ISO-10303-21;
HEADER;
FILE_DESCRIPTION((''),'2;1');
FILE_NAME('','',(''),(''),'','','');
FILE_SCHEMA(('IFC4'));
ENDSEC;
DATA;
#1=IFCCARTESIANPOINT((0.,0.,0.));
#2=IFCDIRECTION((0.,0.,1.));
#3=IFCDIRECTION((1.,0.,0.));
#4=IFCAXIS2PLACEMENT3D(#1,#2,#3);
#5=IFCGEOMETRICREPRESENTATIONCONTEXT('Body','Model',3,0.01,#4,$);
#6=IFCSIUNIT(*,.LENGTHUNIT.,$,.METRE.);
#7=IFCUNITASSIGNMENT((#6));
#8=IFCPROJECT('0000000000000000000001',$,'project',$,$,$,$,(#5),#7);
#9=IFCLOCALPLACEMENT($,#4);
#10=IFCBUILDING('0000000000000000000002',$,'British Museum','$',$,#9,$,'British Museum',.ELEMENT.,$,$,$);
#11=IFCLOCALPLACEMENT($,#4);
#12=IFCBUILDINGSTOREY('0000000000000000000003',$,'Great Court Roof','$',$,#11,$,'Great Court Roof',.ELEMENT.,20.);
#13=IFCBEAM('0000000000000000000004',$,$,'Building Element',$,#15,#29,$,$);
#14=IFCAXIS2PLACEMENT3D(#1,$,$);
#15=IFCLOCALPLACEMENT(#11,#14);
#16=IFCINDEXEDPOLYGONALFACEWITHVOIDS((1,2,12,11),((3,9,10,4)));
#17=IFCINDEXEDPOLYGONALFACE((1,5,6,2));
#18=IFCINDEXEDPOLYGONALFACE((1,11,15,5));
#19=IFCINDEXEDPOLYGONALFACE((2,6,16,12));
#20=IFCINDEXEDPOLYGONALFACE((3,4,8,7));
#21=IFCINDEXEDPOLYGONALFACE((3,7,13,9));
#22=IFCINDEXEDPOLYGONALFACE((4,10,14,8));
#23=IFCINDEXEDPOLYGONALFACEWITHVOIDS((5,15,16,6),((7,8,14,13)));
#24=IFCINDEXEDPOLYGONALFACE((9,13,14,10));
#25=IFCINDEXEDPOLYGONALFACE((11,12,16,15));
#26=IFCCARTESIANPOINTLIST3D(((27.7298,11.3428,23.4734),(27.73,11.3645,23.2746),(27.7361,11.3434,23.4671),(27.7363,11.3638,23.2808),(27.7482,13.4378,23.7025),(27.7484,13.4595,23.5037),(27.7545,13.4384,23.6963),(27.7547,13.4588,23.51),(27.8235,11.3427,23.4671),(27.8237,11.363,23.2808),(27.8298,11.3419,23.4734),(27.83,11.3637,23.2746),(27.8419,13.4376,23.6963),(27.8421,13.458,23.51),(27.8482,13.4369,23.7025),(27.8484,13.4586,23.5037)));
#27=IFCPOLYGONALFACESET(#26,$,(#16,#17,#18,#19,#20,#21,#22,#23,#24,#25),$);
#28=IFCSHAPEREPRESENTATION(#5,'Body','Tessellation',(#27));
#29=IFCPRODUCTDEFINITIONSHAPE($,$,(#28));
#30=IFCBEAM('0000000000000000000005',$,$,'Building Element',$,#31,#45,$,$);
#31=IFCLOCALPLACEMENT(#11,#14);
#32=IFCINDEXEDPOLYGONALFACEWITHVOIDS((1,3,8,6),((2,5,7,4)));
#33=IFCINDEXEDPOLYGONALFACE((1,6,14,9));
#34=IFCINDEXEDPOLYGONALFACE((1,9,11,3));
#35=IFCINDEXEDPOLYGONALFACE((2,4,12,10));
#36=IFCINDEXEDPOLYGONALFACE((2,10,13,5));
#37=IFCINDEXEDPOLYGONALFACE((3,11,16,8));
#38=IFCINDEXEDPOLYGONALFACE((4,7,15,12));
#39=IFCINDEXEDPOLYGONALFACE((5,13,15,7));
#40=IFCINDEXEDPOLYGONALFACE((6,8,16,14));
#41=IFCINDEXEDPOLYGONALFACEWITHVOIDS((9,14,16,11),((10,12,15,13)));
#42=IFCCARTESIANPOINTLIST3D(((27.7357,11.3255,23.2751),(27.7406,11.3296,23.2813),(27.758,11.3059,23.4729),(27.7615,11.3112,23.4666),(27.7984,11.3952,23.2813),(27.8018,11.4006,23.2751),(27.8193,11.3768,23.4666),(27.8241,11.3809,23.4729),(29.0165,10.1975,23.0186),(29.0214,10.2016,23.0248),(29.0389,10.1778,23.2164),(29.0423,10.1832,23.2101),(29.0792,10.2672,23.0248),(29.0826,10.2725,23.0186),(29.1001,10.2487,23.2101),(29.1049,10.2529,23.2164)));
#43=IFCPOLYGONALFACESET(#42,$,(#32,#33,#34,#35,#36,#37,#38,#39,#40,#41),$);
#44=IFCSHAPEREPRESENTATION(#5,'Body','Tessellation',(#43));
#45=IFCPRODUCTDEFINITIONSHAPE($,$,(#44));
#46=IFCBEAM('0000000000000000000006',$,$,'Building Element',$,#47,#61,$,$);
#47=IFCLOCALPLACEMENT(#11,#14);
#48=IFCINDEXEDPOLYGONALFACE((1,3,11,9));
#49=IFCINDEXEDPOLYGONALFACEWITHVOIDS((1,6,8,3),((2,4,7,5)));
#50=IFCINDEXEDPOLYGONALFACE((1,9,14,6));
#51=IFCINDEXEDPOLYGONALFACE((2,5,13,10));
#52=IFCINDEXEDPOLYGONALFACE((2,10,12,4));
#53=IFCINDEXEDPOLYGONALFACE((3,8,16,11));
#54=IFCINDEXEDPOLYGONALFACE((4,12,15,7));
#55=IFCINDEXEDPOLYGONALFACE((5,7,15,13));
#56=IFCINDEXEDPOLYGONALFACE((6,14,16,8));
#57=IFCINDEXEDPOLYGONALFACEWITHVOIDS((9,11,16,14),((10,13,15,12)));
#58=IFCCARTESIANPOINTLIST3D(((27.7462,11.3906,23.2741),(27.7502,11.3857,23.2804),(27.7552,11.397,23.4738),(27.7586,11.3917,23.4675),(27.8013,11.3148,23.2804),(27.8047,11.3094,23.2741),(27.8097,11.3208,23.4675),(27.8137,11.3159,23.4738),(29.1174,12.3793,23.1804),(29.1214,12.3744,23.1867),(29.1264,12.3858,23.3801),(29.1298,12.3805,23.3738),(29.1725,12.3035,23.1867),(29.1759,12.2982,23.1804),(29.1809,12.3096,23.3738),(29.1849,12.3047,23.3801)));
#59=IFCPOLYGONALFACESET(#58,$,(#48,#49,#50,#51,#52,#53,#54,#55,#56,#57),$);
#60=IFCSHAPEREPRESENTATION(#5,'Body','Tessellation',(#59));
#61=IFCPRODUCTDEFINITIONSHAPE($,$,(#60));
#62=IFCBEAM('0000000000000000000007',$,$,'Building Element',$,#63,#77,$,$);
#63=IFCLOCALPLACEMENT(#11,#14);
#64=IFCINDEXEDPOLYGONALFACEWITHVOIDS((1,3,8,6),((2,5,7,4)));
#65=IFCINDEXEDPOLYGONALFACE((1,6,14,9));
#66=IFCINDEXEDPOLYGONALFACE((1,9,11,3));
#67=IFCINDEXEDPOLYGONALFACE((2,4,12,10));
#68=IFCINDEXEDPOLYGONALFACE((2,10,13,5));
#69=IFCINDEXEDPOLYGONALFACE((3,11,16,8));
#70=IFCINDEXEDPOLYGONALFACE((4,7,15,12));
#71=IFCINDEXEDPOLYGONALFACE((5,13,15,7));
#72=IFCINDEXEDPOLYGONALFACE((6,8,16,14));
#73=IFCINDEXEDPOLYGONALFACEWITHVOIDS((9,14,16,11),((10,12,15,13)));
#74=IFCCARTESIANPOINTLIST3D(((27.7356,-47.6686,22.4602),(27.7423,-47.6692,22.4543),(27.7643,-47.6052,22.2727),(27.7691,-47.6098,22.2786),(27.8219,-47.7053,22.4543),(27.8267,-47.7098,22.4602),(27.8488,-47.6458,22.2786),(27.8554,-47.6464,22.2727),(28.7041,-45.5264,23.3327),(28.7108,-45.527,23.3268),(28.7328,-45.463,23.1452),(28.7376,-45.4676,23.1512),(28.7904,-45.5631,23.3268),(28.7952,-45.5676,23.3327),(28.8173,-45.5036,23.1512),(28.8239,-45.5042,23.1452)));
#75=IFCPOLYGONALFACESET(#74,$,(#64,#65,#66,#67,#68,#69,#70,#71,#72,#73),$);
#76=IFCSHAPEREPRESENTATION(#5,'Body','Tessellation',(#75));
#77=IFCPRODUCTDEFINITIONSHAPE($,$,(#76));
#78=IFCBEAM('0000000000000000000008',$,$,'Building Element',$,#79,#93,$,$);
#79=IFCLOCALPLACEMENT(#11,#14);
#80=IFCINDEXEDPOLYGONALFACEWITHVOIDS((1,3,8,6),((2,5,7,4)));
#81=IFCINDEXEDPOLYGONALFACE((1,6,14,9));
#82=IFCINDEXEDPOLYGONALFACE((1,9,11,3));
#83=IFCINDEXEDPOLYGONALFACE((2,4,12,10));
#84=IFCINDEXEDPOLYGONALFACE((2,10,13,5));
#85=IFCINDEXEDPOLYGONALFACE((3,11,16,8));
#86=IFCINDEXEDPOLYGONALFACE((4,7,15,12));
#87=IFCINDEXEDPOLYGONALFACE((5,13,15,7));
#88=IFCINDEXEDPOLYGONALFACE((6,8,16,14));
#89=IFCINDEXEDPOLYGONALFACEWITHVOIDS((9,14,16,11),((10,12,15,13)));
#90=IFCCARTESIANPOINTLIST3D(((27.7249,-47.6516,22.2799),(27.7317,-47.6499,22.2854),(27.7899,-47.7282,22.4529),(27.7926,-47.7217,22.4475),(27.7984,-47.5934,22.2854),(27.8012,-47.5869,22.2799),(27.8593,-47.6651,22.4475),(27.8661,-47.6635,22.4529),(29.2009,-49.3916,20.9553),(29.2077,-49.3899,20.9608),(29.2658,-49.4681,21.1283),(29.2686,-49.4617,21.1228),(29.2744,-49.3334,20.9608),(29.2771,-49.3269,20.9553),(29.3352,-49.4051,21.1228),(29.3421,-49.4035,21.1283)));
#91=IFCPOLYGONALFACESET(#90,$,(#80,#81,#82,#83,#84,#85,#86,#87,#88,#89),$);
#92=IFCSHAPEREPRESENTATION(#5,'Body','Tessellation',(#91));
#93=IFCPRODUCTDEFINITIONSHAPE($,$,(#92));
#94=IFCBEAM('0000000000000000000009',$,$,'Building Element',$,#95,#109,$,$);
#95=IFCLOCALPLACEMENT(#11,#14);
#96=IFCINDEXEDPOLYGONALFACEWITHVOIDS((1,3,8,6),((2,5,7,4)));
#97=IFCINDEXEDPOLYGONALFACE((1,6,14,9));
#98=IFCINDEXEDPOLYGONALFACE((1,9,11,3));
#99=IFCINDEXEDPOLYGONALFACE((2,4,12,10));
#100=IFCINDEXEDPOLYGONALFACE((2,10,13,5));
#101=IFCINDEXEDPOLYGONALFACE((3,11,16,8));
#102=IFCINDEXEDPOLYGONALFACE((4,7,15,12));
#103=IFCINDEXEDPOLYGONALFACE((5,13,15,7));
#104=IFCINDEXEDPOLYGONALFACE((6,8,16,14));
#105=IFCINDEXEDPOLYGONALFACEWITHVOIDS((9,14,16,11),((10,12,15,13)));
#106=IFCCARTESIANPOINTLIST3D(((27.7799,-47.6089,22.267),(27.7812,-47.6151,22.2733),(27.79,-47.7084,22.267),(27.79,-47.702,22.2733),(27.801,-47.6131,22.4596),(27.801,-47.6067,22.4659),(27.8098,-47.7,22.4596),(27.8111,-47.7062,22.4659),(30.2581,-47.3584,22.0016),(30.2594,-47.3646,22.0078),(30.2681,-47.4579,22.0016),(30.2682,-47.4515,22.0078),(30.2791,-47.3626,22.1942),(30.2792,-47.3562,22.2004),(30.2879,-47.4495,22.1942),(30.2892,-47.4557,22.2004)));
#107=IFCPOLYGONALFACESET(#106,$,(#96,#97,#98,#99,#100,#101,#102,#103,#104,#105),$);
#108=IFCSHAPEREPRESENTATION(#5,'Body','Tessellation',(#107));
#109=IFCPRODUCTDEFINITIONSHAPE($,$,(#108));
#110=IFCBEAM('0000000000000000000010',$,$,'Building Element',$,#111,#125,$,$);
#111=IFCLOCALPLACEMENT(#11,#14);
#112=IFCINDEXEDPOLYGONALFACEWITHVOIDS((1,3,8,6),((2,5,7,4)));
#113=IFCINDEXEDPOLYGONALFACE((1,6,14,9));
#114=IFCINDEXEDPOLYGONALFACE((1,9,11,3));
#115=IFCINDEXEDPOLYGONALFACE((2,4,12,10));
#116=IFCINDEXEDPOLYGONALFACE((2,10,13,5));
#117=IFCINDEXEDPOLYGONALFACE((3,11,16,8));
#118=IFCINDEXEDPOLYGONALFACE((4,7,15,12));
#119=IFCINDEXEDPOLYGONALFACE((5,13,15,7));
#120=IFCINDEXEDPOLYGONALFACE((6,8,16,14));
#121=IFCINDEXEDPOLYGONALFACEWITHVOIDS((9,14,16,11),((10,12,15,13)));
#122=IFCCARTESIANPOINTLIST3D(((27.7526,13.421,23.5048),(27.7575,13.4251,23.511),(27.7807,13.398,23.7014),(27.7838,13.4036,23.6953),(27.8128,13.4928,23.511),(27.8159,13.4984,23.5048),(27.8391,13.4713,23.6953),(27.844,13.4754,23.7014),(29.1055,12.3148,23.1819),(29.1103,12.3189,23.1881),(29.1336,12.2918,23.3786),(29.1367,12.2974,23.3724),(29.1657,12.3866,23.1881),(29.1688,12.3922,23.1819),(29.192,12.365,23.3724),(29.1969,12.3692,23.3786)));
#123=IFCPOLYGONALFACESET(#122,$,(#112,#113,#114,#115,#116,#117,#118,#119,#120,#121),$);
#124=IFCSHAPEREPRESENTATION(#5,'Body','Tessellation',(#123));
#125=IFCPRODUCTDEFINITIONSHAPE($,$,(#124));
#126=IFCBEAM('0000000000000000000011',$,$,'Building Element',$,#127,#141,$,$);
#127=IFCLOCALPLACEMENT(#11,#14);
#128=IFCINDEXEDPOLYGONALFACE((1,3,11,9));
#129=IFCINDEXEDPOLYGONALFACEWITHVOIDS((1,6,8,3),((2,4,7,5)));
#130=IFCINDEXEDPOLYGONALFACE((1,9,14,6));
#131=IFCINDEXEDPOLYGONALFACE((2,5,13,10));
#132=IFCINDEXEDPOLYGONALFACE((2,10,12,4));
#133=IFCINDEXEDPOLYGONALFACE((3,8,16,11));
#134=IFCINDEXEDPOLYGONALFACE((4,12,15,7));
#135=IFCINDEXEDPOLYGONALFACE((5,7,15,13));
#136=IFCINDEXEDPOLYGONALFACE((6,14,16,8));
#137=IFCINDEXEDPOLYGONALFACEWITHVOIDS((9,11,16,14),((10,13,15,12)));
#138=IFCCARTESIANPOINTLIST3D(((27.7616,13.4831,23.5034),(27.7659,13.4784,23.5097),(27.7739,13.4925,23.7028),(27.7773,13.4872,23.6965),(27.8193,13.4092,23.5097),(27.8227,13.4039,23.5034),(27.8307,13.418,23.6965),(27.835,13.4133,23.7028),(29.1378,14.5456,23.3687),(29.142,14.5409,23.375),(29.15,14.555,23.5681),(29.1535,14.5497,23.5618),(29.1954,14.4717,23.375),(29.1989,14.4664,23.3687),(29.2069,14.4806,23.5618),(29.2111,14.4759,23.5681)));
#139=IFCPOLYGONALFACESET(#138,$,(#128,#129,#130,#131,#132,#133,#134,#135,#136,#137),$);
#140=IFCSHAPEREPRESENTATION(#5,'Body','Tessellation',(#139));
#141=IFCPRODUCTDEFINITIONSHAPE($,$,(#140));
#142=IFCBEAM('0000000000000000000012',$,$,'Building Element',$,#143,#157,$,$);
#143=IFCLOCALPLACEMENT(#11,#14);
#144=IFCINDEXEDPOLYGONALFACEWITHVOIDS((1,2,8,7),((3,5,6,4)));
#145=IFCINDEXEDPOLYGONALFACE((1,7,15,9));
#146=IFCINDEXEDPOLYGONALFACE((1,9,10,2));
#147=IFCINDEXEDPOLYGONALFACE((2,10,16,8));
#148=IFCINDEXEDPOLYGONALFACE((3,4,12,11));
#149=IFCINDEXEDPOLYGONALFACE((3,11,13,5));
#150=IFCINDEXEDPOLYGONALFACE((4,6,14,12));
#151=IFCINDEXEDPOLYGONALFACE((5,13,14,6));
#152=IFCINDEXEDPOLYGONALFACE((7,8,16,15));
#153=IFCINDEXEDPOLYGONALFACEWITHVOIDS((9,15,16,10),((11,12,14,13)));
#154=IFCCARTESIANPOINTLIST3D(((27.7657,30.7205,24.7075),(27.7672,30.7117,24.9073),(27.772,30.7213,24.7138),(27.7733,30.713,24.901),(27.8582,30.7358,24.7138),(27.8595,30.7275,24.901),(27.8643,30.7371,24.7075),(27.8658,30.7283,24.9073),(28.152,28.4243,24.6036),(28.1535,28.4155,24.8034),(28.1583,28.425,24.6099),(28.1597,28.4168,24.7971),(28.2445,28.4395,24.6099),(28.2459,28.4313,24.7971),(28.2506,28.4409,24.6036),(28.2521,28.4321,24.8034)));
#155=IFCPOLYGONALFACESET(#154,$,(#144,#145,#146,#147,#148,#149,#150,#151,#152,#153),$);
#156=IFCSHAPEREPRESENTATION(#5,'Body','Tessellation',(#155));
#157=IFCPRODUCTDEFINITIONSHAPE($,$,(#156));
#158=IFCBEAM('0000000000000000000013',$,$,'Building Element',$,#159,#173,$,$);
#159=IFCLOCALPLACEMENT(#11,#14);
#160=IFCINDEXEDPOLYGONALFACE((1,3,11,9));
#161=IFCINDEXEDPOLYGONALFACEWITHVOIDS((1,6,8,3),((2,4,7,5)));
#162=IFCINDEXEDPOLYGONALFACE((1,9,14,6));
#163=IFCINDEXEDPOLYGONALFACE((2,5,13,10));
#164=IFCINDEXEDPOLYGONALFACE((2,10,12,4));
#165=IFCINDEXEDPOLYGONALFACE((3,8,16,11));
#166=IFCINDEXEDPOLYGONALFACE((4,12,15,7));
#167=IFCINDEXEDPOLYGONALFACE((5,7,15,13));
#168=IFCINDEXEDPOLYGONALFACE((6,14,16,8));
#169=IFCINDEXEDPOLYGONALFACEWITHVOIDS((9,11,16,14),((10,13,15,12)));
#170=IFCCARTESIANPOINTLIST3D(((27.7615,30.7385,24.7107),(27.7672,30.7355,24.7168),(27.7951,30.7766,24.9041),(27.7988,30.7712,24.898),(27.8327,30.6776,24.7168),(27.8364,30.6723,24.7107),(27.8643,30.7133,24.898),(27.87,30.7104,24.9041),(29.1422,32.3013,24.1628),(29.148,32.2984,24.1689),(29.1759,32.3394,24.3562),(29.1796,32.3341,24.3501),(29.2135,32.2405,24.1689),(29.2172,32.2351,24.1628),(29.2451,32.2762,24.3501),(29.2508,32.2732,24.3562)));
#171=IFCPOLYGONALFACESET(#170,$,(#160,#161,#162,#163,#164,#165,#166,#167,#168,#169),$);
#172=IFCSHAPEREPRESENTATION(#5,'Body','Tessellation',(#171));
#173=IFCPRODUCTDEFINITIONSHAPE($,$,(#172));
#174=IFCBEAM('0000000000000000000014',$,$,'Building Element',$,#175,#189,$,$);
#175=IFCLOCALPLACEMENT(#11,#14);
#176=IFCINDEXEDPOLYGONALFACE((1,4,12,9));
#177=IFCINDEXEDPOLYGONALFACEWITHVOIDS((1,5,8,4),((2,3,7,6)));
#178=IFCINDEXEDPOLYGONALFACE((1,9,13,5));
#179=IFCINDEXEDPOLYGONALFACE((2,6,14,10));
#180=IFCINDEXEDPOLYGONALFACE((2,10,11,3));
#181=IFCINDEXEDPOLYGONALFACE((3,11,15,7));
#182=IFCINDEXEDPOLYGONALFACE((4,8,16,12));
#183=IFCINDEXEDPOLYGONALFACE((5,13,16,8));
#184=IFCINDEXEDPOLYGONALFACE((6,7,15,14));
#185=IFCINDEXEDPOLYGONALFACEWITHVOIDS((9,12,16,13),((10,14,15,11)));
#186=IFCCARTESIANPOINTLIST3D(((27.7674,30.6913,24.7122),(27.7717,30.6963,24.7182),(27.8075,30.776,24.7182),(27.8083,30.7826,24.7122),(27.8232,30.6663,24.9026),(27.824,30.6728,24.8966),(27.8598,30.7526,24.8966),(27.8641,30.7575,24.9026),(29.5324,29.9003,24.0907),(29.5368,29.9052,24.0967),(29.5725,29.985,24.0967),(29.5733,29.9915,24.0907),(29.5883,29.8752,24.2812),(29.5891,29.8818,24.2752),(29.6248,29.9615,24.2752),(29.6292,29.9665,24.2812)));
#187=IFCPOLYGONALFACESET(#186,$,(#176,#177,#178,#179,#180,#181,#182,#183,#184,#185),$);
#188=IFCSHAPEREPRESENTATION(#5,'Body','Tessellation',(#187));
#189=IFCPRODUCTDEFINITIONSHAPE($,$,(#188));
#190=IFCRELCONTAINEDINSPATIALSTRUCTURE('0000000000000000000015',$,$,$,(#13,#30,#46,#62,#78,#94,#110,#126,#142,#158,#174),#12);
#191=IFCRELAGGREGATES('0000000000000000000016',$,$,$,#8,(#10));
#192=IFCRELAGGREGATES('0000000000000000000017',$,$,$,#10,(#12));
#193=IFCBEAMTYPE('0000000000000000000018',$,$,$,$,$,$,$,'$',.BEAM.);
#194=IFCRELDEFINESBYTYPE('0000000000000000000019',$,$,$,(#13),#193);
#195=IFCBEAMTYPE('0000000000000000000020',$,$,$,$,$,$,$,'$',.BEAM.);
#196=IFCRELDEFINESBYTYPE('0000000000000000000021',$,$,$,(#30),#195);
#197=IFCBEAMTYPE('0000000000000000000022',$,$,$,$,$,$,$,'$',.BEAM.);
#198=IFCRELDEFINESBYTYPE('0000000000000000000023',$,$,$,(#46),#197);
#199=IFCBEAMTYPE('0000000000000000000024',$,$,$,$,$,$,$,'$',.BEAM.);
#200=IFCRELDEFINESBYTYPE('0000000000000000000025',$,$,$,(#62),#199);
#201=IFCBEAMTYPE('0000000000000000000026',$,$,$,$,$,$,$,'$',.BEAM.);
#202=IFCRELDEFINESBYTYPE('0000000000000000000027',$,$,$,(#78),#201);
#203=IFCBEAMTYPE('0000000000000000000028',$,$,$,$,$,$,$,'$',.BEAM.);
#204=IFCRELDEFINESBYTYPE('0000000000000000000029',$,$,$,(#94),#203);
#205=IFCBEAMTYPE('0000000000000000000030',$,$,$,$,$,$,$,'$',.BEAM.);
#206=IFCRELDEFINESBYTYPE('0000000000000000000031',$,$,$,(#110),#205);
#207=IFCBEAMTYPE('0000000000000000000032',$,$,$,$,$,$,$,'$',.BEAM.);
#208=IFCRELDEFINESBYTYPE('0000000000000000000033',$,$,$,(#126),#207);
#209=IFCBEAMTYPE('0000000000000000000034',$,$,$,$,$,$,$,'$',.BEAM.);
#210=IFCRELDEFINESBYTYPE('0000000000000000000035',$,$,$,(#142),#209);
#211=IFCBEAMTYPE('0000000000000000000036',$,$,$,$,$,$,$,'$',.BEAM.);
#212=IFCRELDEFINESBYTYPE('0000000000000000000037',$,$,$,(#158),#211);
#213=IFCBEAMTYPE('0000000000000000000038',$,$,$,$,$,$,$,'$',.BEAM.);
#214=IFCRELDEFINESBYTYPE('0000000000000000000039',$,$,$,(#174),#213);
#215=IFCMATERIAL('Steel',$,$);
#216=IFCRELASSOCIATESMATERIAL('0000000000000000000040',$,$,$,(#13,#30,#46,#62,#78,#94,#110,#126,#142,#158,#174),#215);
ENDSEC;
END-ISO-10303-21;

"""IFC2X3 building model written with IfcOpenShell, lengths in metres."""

from ifc_helpers import new_model, si_unit, frame, origin_with_axes, origin_2d, place, context, project, spatial, hollow_rectangle, extrude, material, type_object, element, save


model = new_model("IFC2X3")

# Units and contexts
model_context = context("Model", 3, precision=0.01, world=origin_with_axes(), identifier="Body")
ifc_project = project(units=[si_unit("LENGTHUNIT", "METRE")], contexts=[model_context])

# Building, storey
building_placement = place(None, origin_with_axes())
building = spatial("IfcBuilding", under=ifc_project, at=building_placement, Name="British Museum", Description="$", LongName="British Museum", CompositionType="ELEMENT")
storey_placement = place(None, origin_with_axes())
storey = spatial("IfcBuildingStorey", under=building, at=storey_placement, Name="Great Court Roof", Description="$", LongName="Great Court Roof", CompositionType="ELEMENT", Elevation=20.0)

# Beams
ifc_material = material(Name="Steel")
beam_type_1 = type_object("IfcBeamType", ElementType="$", PredefinedType="BEAM")
beam_1_placement = place(None, origin_with_axes())
element("IfcBeam", 1, at=beam_1_placement, inside=storey, type_object=beam_type_1, material=ifc_material, Description="Building Element", context=model_context, shape_type="SweptSolid", body=[
    extrude(hollow_rectangle(XDim=0.1, YDim=0.2, WallThickness=0.0063, InnerFilletRadius=-0.0063, OuterFilletRadius=0.0, at=origin_2d()), frame((27.7799, 11.3532, 23.374), z_axis=(0.008719, 0.994035, 0.108716), x_axis=(-0.999962, 0.008771, 0.0)), (0.0, 0.0, 1.0), 2.1075),
])
beam_type_2 = type_object("IfcBeamType", ElementType="$", PredefinedType="BEAM")
beam_2_placement = place(None, origin_with_axes())
element("IfcBeam", 2, at=beam_2_placement, inside=storey, type_object=beam_type_2, material=ifc_material, Description="Building Element", context=model_context, shape_type="SweptSolid", body=[
    extrude(hollow_rectangle(XDim=0.1, YDim=0.2, WallThickness=0.0063, InnerFilletRadius=-0.0063, OuterFilletRadius=0.0, at=origin_2d()), frame((27.7799, 11.3532, 23.374), z_axis=(0.742103, -0.653603, -0.148617), x_axis=(0.660943, 0.750437, 0.0)), (0.0, 0.0, 1.0), 1.7259),
])
beam_type_3 = type_object("IfcBeamType", ElementType="$", PredefinedType="BEAM")
beam_3_placement = place(None, origin_with_axes())
element("IfcBeam", 3, at=beam_3_placement, inside=storey, type_object=beam_type_3, material=ifc_material, Description="Building Element", context=model_context, shape_type="SweptSolid", body=[
    extrude(hollow_rectangle(XDim=0.1, YDim=0.2, WallThickness=0.0063, InnerFilletRadius=-0.0063, OuterFilletRadius=0.0, at=origin_2d()), frame((27.7799, 11.3532, 23.374), z_axis=(0.809885, 0.583972, -0.055345), x_axis=(-0.584868, 0.811128, 0.0)), (0.0, 0.0, 1.0), 1.6932),
])
beam_type_4 = type_object("IfcBeamType", ElementType="$", PredefinedType="BEAM")
beam_4_placement = place(None, origin_with_axes())
element("IfcBeam", 4, at=beam_4_placement, inside=storey, type_object=beam_type_4, material=ifc_material, Description="Building Element", context=model_context, shape_type="SweptSolid", body=[
    extrude(hollow_rectangle(XDim=0.1, YDim=0.2, WallThickness=0.0063, InnerFilletRadius=-0.0063, OuterFilletRadius=0.0, at=origin_2d()), frame((27.7955, -47.6575, 22.3664), z_axis=(0.386216, 0.85426, 0.347962), x_axis=(-0.911202, 0.411959, 0.0)), (0.0, 0.0, 1.0), 2.5077),
])
beam_type_5 = type_object("IfcBeamType", ElementType="$", PredefinedType="BEAM")
beam_5_placement = place(None, origin_with_axes())
element("IfcBeam", 5, at=beam_5_placement, inside=storey, type_object=beam_type_5, material=ifc_material, Description="Building Element", context=model_context, shape_type="SweptSolid", body=[
    extrude(hollow_rectangle(XDim=0.1, YDim=0.2, WallThickness=0.0063, InnerFilletRadius=-0.0063, OuterFilletRadius=0.0, at=origin_2d()), frame((27.7955, -47.6575, 22.3664), z_axis=(0.559438, -0.659507, -0.502076), x_axis=(0.762591, 0.646881, 0.0)), (0.0, 0.0, 1.0), 2.6383),
])
beam_type_6 = type_object("IfcBeamType", ElementType="$", PredefinedType="BEAM")
beam_6_placement = place(None, origin_with_axes())
element("IfcBeam", 6, at=beam_6_placement, inside=storey, type_object=beam_type_6, material=ifc_material, Description="Building Element", context=model_context, shape_type="SweptSolid", body=[
    extrude(hollow_rectangle(XDim=0.1, YDim=0.2, WallThickness=0.0063, InnerFilletRadius=-0.0063, OuterFilletRadius=0.0, at=origin_2d()), frame((27.7955, -47.6575, 22.3664), z_axis=(0.989328, 0.100005, -0.105967), x_axis=(-0.100571, 0.99493, 0.0)), (0.0, 0.0, 1.0), 2.5049),
])
beam_type_7 = type_object("IfcBeamType", ElementType="$", PredefinedType="BEAM")
beam_7_placement = place(None, origin_with_axes())
element("IfcBeam", 7, at=beam_7_placement, inside=storey, type_object=beam_type_7, material=ifc_material, Description="Building Element", context=model_context, shape_type="SweptSolid", body=[
    extrude(hollow_rectangle(XDim=0.1, YDim=0.2, WallThickness=0.0063, InnerFilletRadius=-0.0063, OuterFilletRadius=0.0, at=origin_2d()), frame((27.7983, 13.4482, 23.6031), z_axis=(0.761272, -0.622467, -0.181657), x_axis=(0.632999, 0.774152, 0.0)), (0.0, 0.0, 1.0), 1.7771),
])
beam_type_8 = type_object("IfcBeamType", ElementType="$", PredefinedType="BEAM")
beam_8_placement = place(None, origin_with_axes())
element("IfcBeam", 8, at=beam_8_placement, inside=storey, type_object=beam_type_8, material=ifc_material, Description="Building Element", context=model_context, shape_type="SweptSolid", body=[
    extrude(hollow_rectangle(XDim=0.1, YDim=0.2, WallThickness=0.0063, InnerFilletRadius=-0.0063, OuterFilletRadius=0.0, at=origin_2d()), frame((27.7983, 13.4482, 23.6031), z_axis=(0.789163, 0.609307, -0.077246), x_axis=(-0.611133, 0.791528, 0.0)), (0.0, 0.0, 1.0), 1.7438),
])
beam_type_9 = type_object("IfcBeamType", ElementType="$", PredefinedType="BEAM")
beam_9_placement = place(None, origin_with_axes())
element("IfcBeam", 9, at=beam_9_placement, inside=storey, type_object=beam_type_9, material=ifc_material, Description="Building Element", context=model_context, shape_type="SweptSolid", body=[
    extrude(hollow_rectangle(XDim=0.1, YDim=0.2, WallThickness=0.0063, InnerFilletRadius=-0.0063, OuterFilletRadius=0.0, at=origin_2d()), frame((27.8158, 30.7244, 24.8074), z_axis=(0.165746, -0.98516, -0.044589), x_axis=(0.986141, 0.165911, 0.0)), (0.0, 0.0, 1.0), 2.3308),
])
beam_type_10 = type_object("IfcBeamType", ElementType="$", PredefinedType="BEAM")
beam_10_placement = place(None, origin_with_axes())
element("IfcBeam", 10, at=beam_10_placement, inside=storey, type_object=beam_type_10, material=ifc_material, Description="Building Element", context=model_context, shape_type="SweptSolid", body=[
    extrude(hollow_rectangle(XDim=0.1, YDim=0.2, WallThickness=0.0063, InnerFilletRadius=-0.0063, OuterFilletRadius=0.0, at=origin_2d()), frame((27.8158, 30.7244, 24.8074), z_axis=(0.640374, 0.724815, -0.254096), x_axis=(-0.749411, 0.662105, 0.0)), (0.0, 0.0, 1.0), 2.1562),
])
beam_type_11 = type_object("IfcBeamType", ElementType="$", PredefinedType="BEAM")
beam_11_placement = place(None, origin_with_axes())
element("IfcBeam", 11, at=beam_11_placement, inside=storey, type_object=beam_type_11, material=ifc_material, Description="Building Element", context=model_context, shape_type="SweptSolid", body=[
    extrude(hollow_rectangle(XDim=0.1, YDim=0.2, WallThickness=0.0063, InnerFilletRadius=-0.0063, OuterFilletRadius=0.0, at=origin_2d()), frame((27.8158, 30.7244, 24.8074), z_axis=(0.868802, -0.389369, -0.3059), x_axis=(0.408974, 0.912546, 0.0)), (0.0, 0.0, 1.0), 2.0316),
])

save(model, "model.ifc")
